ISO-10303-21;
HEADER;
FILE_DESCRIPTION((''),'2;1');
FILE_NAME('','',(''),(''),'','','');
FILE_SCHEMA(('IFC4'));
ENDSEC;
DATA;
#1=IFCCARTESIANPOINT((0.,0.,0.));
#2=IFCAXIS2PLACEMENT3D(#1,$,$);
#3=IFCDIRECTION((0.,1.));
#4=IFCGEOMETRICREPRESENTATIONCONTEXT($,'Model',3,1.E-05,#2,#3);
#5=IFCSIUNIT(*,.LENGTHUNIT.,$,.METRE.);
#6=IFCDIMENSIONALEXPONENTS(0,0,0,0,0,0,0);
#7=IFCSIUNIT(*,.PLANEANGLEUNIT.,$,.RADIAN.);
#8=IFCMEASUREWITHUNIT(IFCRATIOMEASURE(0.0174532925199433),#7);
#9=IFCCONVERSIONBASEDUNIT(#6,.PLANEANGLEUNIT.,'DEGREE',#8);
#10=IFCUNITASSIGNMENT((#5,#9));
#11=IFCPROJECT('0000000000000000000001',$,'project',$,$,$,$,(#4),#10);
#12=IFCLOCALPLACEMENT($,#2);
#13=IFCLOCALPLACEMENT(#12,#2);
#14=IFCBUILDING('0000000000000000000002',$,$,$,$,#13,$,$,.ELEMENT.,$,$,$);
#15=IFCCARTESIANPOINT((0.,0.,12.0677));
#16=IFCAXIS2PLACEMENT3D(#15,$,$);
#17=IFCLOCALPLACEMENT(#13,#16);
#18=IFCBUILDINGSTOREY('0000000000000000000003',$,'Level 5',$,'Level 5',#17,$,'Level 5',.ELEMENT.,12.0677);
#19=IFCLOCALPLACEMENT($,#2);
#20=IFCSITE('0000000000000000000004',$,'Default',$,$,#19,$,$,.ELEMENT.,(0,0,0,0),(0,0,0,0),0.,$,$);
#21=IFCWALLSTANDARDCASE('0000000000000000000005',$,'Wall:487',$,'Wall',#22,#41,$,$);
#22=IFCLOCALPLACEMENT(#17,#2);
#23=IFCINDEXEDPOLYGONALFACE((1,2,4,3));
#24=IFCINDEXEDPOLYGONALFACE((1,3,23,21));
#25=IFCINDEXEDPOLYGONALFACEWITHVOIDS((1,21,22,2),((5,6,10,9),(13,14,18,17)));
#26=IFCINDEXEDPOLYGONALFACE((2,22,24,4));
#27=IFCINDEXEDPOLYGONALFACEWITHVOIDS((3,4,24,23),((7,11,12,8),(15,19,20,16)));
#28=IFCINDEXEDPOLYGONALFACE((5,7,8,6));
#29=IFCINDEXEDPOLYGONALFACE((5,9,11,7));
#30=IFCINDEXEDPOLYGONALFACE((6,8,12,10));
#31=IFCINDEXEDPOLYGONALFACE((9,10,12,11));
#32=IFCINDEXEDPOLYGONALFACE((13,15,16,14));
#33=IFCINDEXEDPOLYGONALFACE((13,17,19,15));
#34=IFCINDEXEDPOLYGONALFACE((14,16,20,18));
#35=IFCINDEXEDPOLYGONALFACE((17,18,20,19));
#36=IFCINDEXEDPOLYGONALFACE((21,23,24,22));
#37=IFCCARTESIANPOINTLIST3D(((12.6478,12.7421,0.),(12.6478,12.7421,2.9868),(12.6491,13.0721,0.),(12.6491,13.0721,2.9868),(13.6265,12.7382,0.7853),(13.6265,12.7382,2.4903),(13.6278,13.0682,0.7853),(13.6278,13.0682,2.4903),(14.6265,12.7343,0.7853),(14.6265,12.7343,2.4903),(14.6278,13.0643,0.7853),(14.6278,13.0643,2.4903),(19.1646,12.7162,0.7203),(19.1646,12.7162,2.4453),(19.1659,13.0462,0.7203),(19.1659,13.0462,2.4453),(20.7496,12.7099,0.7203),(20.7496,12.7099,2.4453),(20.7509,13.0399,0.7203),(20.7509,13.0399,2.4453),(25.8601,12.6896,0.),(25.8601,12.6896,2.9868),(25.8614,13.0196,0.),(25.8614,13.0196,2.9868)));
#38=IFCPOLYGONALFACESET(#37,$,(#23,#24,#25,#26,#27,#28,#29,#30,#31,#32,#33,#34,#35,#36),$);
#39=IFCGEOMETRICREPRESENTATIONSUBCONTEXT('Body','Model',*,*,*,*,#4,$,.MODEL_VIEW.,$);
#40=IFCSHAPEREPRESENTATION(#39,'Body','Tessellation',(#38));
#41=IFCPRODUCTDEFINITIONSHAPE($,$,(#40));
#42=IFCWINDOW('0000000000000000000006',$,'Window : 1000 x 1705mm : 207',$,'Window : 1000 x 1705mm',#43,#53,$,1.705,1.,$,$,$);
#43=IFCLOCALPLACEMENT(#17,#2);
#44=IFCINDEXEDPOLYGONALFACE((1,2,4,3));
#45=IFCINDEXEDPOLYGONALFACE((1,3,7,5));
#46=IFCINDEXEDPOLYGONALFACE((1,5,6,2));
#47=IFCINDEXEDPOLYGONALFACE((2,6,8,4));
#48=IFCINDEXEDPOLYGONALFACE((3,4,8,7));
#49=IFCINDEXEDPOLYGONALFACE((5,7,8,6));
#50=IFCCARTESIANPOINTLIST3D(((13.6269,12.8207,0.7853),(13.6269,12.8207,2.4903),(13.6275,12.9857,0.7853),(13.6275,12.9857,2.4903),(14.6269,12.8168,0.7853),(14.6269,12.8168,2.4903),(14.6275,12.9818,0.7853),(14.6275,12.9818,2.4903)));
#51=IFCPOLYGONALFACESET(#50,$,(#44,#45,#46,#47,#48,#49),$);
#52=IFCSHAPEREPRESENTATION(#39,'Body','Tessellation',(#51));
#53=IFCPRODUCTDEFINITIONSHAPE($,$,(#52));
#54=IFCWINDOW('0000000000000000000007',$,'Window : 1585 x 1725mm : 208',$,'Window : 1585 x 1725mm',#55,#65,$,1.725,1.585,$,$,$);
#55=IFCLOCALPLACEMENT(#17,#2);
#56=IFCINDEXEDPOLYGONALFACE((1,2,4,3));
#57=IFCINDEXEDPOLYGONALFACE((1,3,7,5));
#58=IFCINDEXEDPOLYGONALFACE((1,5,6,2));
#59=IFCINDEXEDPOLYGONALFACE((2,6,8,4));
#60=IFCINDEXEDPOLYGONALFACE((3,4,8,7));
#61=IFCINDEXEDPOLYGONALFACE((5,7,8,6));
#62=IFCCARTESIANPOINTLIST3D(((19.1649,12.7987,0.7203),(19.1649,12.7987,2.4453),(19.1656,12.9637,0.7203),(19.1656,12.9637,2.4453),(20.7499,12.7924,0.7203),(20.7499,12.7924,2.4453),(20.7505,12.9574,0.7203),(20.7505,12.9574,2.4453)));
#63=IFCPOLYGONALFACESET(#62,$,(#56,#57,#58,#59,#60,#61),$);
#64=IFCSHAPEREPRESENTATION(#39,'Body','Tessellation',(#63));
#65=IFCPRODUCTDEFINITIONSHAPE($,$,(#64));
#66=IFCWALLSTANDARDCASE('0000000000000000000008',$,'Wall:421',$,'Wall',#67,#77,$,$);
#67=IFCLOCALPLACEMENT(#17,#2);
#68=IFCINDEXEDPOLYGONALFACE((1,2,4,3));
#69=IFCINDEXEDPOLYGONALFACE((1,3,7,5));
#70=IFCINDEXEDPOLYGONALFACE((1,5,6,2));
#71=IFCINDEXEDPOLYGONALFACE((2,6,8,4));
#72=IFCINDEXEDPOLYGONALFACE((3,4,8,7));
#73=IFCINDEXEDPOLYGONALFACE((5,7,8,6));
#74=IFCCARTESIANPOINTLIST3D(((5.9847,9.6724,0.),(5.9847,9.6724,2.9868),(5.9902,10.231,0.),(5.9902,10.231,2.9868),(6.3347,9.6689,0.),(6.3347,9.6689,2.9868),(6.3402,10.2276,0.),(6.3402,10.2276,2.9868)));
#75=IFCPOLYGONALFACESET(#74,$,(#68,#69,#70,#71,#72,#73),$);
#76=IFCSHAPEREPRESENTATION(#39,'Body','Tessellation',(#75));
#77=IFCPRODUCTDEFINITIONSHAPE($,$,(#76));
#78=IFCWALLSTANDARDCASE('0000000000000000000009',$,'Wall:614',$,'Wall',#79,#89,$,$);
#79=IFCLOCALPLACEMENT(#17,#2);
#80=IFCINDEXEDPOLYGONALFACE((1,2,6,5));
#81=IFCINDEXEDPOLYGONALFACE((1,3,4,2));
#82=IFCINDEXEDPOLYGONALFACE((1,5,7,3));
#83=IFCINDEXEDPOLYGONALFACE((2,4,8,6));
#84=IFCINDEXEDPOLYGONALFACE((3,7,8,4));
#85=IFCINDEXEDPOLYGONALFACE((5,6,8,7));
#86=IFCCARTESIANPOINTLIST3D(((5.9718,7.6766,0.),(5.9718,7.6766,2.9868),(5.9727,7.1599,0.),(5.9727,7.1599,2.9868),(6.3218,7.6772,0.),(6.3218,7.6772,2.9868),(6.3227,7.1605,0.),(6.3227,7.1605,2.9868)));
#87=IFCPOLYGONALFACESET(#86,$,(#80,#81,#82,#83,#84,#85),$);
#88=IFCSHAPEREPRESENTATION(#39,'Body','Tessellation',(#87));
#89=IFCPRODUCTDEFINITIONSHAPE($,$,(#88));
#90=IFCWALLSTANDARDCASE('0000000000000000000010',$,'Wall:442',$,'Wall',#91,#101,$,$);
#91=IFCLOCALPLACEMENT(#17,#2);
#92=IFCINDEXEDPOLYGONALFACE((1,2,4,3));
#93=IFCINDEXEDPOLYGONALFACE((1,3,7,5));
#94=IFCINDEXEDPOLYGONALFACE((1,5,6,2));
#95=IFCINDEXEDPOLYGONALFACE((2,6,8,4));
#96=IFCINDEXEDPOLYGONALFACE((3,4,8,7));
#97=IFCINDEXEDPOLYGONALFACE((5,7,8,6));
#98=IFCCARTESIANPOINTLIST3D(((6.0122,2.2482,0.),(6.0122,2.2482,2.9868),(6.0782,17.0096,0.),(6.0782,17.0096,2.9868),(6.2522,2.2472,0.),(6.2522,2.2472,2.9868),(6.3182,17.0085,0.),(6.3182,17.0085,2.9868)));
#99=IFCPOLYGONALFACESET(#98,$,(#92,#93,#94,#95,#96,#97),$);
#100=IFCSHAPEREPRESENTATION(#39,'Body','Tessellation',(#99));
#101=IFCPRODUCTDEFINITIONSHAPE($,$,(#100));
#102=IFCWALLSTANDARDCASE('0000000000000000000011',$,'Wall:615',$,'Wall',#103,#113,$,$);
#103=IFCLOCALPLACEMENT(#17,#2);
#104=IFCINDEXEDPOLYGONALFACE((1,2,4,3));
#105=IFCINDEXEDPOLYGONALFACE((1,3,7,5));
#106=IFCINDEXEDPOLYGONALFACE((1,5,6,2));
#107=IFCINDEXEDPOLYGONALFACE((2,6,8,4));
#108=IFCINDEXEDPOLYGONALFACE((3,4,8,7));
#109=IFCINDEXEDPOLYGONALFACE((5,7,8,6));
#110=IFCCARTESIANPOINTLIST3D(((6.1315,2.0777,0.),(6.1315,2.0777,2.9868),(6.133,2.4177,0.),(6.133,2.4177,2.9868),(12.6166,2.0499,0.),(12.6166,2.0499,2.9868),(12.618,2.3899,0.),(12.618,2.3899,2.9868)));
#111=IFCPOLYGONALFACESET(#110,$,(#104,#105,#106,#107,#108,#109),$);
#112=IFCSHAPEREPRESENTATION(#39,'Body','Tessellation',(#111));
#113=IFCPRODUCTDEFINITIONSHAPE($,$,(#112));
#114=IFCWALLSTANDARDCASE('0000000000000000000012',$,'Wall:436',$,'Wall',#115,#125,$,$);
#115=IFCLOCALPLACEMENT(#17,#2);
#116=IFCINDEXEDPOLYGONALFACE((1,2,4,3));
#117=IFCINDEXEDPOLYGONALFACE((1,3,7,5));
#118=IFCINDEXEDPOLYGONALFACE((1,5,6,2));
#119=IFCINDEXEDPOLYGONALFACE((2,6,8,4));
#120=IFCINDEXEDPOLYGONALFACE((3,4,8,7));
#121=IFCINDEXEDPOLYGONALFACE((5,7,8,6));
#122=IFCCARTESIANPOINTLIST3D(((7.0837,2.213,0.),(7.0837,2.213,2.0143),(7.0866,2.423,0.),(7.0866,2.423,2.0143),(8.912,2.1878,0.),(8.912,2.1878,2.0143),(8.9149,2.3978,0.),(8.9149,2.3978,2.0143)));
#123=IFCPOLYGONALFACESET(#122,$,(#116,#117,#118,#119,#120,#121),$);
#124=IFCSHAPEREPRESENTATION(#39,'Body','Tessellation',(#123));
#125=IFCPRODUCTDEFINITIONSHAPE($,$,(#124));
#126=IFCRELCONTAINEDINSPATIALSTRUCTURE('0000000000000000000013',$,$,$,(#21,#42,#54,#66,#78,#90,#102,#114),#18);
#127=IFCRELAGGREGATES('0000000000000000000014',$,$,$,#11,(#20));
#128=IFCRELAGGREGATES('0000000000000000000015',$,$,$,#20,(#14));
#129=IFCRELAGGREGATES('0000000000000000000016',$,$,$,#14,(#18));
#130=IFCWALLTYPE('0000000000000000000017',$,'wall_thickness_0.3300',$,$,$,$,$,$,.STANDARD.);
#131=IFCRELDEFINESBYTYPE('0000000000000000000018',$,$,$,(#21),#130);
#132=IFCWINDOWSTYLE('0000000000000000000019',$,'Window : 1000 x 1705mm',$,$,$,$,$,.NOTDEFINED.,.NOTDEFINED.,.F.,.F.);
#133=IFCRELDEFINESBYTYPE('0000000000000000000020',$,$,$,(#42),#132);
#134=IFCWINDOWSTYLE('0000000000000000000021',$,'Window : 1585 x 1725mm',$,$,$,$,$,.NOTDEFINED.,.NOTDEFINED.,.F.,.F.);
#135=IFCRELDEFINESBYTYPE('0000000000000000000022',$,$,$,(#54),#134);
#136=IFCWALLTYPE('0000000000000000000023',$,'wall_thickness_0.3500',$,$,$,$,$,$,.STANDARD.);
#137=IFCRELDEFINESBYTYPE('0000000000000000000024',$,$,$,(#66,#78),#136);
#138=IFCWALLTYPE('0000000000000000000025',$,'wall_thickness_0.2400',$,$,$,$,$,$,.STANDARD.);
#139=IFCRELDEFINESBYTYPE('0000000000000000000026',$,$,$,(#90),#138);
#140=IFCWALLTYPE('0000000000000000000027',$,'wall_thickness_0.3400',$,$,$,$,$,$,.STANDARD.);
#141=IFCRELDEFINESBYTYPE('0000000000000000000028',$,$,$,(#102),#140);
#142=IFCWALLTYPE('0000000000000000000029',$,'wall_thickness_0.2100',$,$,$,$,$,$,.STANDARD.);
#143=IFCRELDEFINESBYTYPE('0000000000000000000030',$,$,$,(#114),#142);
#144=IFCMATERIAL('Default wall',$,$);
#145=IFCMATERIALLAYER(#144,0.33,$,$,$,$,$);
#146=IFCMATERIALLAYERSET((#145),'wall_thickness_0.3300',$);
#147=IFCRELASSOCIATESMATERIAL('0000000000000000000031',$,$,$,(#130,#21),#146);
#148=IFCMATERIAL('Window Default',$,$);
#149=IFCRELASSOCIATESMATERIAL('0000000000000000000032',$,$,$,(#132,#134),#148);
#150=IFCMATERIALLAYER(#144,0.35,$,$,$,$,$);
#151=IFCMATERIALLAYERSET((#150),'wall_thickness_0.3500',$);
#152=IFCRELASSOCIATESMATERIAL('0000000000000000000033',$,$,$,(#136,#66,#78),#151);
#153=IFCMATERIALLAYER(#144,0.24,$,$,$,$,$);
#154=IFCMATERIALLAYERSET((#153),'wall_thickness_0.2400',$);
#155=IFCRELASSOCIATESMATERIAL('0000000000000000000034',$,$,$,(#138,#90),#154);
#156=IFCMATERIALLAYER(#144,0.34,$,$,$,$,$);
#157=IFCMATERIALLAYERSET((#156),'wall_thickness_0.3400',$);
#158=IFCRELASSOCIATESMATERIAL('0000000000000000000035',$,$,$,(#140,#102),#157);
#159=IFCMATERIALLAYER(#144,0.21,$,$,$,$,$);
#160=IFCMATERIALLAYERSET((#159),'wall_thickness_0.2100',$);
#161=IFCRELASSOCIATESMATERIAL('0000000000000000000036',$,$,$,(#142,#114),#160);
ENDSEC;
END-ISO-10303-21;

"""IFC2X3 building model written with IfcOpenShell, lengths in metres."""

from ifc_helpers import new_model, entity, si_unit, converted_unit, direction, frame, frame_2d, origin, origin_2d_with_axis, place, context, subcontext, project, spatial, polyline, rectangle, outline, extrude, source, transform, mapped, material, layer, layer_set, layer_usage, type_object, type_shapes, element, fill, save


model = new_model("IFC2X3")

# Units and contexts
model_context = context("Model", 3, precision=1e-05, world=origin(), true_north=direction((0.0, 1.0)))
body_context = subcontext(model_context, "Body", "Model", "MODEL_VIEW")
ifc_project = project(units=[si_unit("LENGTHUNIT", "METRE"), converted_unit("PLANEANGLEUNIT", "DEGREE", entity("IfcRatioMeasure", 0.0174532925199433), si_unit("PLANEANGLEUNIT", "RADIAN"), dimensions=[0, 0, 0, 0, 0, 0, 0])], contexts=[model_context])

# Site, building, storey
site_placement = place(None, origin())
site = spatial("IfcSite", under=ifc_project, at=site_placement, Name="Default", CompositionType="ELEMENT", RefLatitude=(0, 0, 0, 0), RefLongitude=(0, 0, 0, 0), RefElevation=0.0)
placement_1 = place(None, origin())
building_placement = place(placement_1, origin())
building = spatial("IfcBuilding", under=site, at=building_placement, CompositionType="ELEMENT")
storey_placement = place(building_placement, frame((0.0, 0.0, 12.0677)))
storey = spatial("IfcBuildingStorey", under=building, at=storey_placement, Name="Level 5", ObjectType="Level 5", LongName="Level 5", CompositionType="ELEMENT", Elevation=12.0677)

# Shared definitions
ifc_material_1 = material(Name="Default wall")

# Shared definitions
ifc_material_2 = material(Name="Window Default")

# Wall, openings, windows
ifc_layer_1 = layer(ifc_material_1, 0.33)
ifc_layer_set_1 = layer_set([ifc_layer_1], Name="wall_thickness_0.3300")
ifc_layer_usage_1 = layer_usage(ifc_layer_set_1, "AXIS2", "POSITIVE", -0.165)
wall_type_1 = type_object("IfcWallType", Name="wall_thickness_0.3300", PredefinedType="STANDARD", material=ifc_layer_set_1)
wall_1_placement = place(storey_placement, frame((12.6484, 12.9071, 0.0), z_axis=(0.0, 0.0, 1.0), x_axis=(0.999992, -0.003972, 0.0)))
wall_1 = element("IfcWallStandardCase", 1, at=wall_1_placement, inside=storey, type_object=wall_type_1, material=ifc_layer_usage_1, Name="Wall:487", ObjectType="Wall", context=body_context, shape_type="SweptSolid", body=[
    extrude(outline(polyline([(13.2124, -0.165), (13.2124, 0.165), (0.0, 0.165), (0.0, -0.165), (13.2124, -0.165)])), origin(), (0.0, 0.0, 1.0), 2.9868),
])
opening_1_placement = place(wall_1_placement, frame((0.9788, -0.165, 0.7853)))
opening_1 = element("IfcOpeningElement", 2, at=opening_1_placement, cuts=wall_1, ObjectType="Opening", context=body_context, shape_type="SweptSolid", body=[
    extrude(rectangle(XDim=1.0, YDim=1.705, at=frame_2d((0.8525, 0.5), x_axis=(0.0, 1.0))), frame((0.0, 0.0, 0.0), z_axis=(0.0, 1.0, 0.0), x_axis=(0.0, 0.0, 1.0)), (0.0, 0.0, 1.0), 0.33),
])
opening_2_placement = place(wall_1_placement, frame((6.5169, -0.165, 0.7203)))
opening_2 = element("IfcOpeningElement", 3, at=opening_2_placement, cuts=wall_1, ObjectType="Opening", context=body_context, shape_type="SweptSolid", body=[
    extrude(rectangle(XDim=1.585, YDim=1.725, at=frame_2d((0.8625, 0.7925), x_axis=(0.0, 1.0))), frame((0.0, 0.0, 0.0), z_axis=(0.0, 1.0, 0.0), x_axis=(0.0, 0.0, 1.0)), (0.0, 0.0, 1.0), 0.33),
])
window_style_1 = type_object("IfcWindowStyle", Name="Window : 1000 x 1705mm", ConstructionType="NOTDEFINED", OperationType="NOTDEFINED", ParameterTakesPrecedence=False, Sizeable=False, material=ifc_material_2)
shared_shape_1 = source(origin(), body_context, "Body", "SweptSolid", [
    extrude(rectangle(XDim=0.165, YDim=1.0, at=origin_2d_with_axis()), frame((0.5, 0.165, 0.0), z_axis=(0.0, 0.0, 1.0), x_axis=(0.0, 1.0, 0.0)), (0.0, 0.0, 1.0), 1.705),
])
type_shapes(window_style_1, [shared_shape_1])
window_1_placement = place(opening_1_placement, origin())
window_1 = element("IfcWindow", 4, at=window_1_placement, inside=storey, type_object=window_style_1, Name="Window : 1000 x 1705mm : 207", ObjectType="Window : 1000 x 1705mm", OverallHeight=1.705, OverallWidth=1.0, context=body_context, shape_type="MappedRepresentation", body=[
    mapped(shared_shape_1, transform((0.0, 0.0, 0.0), scale=1.0)),
])
fill(opening_1, window_1)
window_style_2 = type_object("IfcWindowStyle", Name="Window : 1585 x 1725mm", ConstructionType="NOTDEFINED", OperationType="NOTDEFINED", ParameterTakesPrecedence=False, Sizeable=False, material=ifc_material_2)
shared_shape_2 = source(origin(), body_context, "Body", "SweptSolid", [
    extrude(rectangle(XDim=0.165, YDim=1.585, at=origin_2d_with_axis()), frame((0.7925, 0.165, 0.0), z_axis=(0.0, 0.0, 1.0), x_axis=(0.0, 1.0, 0.0)), (0.0, 0.0, 1.0), 1.725),
])
type_shapes(window_style_2, [shared_shape_2])
window_2_placement = place(opening_2_placement, origin())
window_2 = element("IfcWindow", 5, at=window_2_placement, inside=storey, type_object=window_style_2, Name="Window : 1585 x 1725mm : 208", ObjectType="Window : 1585 x 1725mm", OverallHeight=1.725, OverallWidth=1.585, context=body_context, shape_type="MappedRepresentation", body=[
    mapped(shared_shape_2, transform((0.0, 0.0, 0.0), scale=1.0)),
])
fill(opening_2, window_2)

# Walls
ifc_layer_2 = layer(ifc_material_1, 0.35)
ifc_layer_set_2 = layer_set([ifc_layer_2], Name="wall_thickness_0.3500")
ifc_layer_usage_2 = layer_usage(ifc_layer_set_2, "AXIS2", "POSITIVE", -0.175)
wall_type_2 = type_object("IfcWallType", Name="wall_thickness_0.3500", PredefinedType="STANDARD", material=ifc_layer_set_2)
wall_2_placement = place(storey_placement, frame((6.1652, 10.2293, 0.0), z_axis=(0.0, 0.0, 1.0), x_axis=(-0.009853, -0.999951, 0.0)))
element("IfcWallStandardCase", 6, at=wall_2_placement, inside=storey, type_object=wall_type_2, material=ifc_layer_usage_2, Name="Wall:421", ObjectType="Wall", context=body_context, shape_type="SweptSolid", body=[
    extrude(outline(polyline([(0.5587, -0.175), (0.5587, 0.175), (0.0, 0.175), (0.0, -0.175), (0.5587, -0.175)])), origin(), (0.0, 0.0, 1.0), 2.9868),
])
wall_3_placement = place(storey_placement, frame((6.1468, 7.6769, 0.0), z_axis=(0.0, 0.0, 1.0), x_axis=(0.001699, -0.999999, 0.0)))
element("IfcWallStandardCase", 7, at=wall_3_placement, inside=storey, type_object=wall_type_2, material=ifc_layer_usage_2, Name="Wall:614", ObjectType="Wall", context=body_context, shape_type="SweptSolid", body=[
    extrude(outline(polyline([(0.5168, -0.175), (0.5168, 0.175), (0.0, 0.175), (0.0, -0.175), (0.5168, -0.175)])), origin(), (0.0, 0.0, 1.0), 2.9868),
])
ifc_layer_3 = layer(ifc_material_1, 0.24)
ifc_layer_set_3 = layer_set([ifc_layer_3], Name="wall_thickness_0.2400")
ifc_layer_usage_3 = layer_usage(ifc_layer_set_3, "AXIS2", "POSITIVE", -0.12)
wall_type_3 = type_object("IfcWallType", Name="wall_thickness_0.2400", PredefinedType="STANDARD", material=ifc_layer_set_3)
wall_4_placement = place(storey_placement, frame((6.1982, 17.009, 0.0), z_axis=(0.0, 0.0, 1.0), x_axis=(-0.004469, -0.99999, 0.0)))
element("IfcWallStandardCase", 8, at=wall_4_placement, inside=storey, type_object=wall_type_3, material=ifc_layer_usage_3, Name="Wall:442", ObjectType="Wall", context=body_context, shape_type="SweptSolid", body=[
    extrude(outline(polyline([(14.7615, -0.12), (14.7615, 0.12), (0.0, 0.12), (0.0, -0.12), (14.7615, -0.12)])), origin(), (0.0, 0.0, 1.0), 2.9868),
])
ifc_layer_4 = layer(ifc_material_1, 0.34)
ifc_layer_set_4 = layer_set([ifc_layer_4], Name="wall_thickness_0.3400")
ifc_layer_usage_4 = layer_usage(ifc_layer_set_4, "AXIS2", "POSITIVE", -0.17)
wall_type_4 = type_object("IfcWallType", Name="wall_thickness_0.3400", PredefinedType="STANDARD", material=ifc_layer_set_4)
wall_5_placement = place(storey_placement, frame((6.1322, 2.2477, 0.0), z_axis=(0.0, 0.0, 1.0), x_axis=(0.999991, -0.004281, 0.0)))
element("IfcWallStandardCase", 9, at=wall_5_placement, inside=storey, type_object=wall_type_4, material=ifc_layer_usage_4, Name="Wall:615", ObjectType="Wall", context=body_context, shape_type="SweptSolid", body=[
    extrude(outline(polyline([(6.4852, -0.17), (6.4852, 0.17), (0.0, 0.17), (0.0, -0.17), (6.4852, -0.17)])), origin(), (0.0, 0.0, 1.0), 2.9868),
])
ifc_layer_5 = layer(ifc_material_1, 0.21)
ifc_layer_set_5 = layer_set([ifc_layer_5], Name="wall_thickness_0.2100")
ifc_layer_usage_5 = layer_usage(ifc_layer_set_5, "AXIS2", "POSITIVE", -0.105)
wall_type_5 = type_object("IfcWallType", Name="wall_thickness_0.2100", PredefinedType="STANDARD", material=ifc_layer_set_5)
wall_6_placement = place(storey_placement, frame((7.0851, 2.318, 0.0), z_axis=(0.0, 0.0, 1.0), x_axis=(0.999906, -0.013739, 0.0)))
element("IfcWallStandardCase", 10, at=wall_6_placement, inside=storey, type_object=wall_type_5, material=ifc_layer_usage_5, Name="Wall:436", ObjectType="Wall", context=body_context, shape_type="SweptSolid", body=[
    extrude(outline(polyline([(1.8285, -0.105), (1.8285, 0.105), (0.0, 0.105), (0.0, -0.105), (1.8285, -0.105)])), origin(), (0.0, 0.0, 1.0), 2.0143),
])

save(model, "model.ifc")
